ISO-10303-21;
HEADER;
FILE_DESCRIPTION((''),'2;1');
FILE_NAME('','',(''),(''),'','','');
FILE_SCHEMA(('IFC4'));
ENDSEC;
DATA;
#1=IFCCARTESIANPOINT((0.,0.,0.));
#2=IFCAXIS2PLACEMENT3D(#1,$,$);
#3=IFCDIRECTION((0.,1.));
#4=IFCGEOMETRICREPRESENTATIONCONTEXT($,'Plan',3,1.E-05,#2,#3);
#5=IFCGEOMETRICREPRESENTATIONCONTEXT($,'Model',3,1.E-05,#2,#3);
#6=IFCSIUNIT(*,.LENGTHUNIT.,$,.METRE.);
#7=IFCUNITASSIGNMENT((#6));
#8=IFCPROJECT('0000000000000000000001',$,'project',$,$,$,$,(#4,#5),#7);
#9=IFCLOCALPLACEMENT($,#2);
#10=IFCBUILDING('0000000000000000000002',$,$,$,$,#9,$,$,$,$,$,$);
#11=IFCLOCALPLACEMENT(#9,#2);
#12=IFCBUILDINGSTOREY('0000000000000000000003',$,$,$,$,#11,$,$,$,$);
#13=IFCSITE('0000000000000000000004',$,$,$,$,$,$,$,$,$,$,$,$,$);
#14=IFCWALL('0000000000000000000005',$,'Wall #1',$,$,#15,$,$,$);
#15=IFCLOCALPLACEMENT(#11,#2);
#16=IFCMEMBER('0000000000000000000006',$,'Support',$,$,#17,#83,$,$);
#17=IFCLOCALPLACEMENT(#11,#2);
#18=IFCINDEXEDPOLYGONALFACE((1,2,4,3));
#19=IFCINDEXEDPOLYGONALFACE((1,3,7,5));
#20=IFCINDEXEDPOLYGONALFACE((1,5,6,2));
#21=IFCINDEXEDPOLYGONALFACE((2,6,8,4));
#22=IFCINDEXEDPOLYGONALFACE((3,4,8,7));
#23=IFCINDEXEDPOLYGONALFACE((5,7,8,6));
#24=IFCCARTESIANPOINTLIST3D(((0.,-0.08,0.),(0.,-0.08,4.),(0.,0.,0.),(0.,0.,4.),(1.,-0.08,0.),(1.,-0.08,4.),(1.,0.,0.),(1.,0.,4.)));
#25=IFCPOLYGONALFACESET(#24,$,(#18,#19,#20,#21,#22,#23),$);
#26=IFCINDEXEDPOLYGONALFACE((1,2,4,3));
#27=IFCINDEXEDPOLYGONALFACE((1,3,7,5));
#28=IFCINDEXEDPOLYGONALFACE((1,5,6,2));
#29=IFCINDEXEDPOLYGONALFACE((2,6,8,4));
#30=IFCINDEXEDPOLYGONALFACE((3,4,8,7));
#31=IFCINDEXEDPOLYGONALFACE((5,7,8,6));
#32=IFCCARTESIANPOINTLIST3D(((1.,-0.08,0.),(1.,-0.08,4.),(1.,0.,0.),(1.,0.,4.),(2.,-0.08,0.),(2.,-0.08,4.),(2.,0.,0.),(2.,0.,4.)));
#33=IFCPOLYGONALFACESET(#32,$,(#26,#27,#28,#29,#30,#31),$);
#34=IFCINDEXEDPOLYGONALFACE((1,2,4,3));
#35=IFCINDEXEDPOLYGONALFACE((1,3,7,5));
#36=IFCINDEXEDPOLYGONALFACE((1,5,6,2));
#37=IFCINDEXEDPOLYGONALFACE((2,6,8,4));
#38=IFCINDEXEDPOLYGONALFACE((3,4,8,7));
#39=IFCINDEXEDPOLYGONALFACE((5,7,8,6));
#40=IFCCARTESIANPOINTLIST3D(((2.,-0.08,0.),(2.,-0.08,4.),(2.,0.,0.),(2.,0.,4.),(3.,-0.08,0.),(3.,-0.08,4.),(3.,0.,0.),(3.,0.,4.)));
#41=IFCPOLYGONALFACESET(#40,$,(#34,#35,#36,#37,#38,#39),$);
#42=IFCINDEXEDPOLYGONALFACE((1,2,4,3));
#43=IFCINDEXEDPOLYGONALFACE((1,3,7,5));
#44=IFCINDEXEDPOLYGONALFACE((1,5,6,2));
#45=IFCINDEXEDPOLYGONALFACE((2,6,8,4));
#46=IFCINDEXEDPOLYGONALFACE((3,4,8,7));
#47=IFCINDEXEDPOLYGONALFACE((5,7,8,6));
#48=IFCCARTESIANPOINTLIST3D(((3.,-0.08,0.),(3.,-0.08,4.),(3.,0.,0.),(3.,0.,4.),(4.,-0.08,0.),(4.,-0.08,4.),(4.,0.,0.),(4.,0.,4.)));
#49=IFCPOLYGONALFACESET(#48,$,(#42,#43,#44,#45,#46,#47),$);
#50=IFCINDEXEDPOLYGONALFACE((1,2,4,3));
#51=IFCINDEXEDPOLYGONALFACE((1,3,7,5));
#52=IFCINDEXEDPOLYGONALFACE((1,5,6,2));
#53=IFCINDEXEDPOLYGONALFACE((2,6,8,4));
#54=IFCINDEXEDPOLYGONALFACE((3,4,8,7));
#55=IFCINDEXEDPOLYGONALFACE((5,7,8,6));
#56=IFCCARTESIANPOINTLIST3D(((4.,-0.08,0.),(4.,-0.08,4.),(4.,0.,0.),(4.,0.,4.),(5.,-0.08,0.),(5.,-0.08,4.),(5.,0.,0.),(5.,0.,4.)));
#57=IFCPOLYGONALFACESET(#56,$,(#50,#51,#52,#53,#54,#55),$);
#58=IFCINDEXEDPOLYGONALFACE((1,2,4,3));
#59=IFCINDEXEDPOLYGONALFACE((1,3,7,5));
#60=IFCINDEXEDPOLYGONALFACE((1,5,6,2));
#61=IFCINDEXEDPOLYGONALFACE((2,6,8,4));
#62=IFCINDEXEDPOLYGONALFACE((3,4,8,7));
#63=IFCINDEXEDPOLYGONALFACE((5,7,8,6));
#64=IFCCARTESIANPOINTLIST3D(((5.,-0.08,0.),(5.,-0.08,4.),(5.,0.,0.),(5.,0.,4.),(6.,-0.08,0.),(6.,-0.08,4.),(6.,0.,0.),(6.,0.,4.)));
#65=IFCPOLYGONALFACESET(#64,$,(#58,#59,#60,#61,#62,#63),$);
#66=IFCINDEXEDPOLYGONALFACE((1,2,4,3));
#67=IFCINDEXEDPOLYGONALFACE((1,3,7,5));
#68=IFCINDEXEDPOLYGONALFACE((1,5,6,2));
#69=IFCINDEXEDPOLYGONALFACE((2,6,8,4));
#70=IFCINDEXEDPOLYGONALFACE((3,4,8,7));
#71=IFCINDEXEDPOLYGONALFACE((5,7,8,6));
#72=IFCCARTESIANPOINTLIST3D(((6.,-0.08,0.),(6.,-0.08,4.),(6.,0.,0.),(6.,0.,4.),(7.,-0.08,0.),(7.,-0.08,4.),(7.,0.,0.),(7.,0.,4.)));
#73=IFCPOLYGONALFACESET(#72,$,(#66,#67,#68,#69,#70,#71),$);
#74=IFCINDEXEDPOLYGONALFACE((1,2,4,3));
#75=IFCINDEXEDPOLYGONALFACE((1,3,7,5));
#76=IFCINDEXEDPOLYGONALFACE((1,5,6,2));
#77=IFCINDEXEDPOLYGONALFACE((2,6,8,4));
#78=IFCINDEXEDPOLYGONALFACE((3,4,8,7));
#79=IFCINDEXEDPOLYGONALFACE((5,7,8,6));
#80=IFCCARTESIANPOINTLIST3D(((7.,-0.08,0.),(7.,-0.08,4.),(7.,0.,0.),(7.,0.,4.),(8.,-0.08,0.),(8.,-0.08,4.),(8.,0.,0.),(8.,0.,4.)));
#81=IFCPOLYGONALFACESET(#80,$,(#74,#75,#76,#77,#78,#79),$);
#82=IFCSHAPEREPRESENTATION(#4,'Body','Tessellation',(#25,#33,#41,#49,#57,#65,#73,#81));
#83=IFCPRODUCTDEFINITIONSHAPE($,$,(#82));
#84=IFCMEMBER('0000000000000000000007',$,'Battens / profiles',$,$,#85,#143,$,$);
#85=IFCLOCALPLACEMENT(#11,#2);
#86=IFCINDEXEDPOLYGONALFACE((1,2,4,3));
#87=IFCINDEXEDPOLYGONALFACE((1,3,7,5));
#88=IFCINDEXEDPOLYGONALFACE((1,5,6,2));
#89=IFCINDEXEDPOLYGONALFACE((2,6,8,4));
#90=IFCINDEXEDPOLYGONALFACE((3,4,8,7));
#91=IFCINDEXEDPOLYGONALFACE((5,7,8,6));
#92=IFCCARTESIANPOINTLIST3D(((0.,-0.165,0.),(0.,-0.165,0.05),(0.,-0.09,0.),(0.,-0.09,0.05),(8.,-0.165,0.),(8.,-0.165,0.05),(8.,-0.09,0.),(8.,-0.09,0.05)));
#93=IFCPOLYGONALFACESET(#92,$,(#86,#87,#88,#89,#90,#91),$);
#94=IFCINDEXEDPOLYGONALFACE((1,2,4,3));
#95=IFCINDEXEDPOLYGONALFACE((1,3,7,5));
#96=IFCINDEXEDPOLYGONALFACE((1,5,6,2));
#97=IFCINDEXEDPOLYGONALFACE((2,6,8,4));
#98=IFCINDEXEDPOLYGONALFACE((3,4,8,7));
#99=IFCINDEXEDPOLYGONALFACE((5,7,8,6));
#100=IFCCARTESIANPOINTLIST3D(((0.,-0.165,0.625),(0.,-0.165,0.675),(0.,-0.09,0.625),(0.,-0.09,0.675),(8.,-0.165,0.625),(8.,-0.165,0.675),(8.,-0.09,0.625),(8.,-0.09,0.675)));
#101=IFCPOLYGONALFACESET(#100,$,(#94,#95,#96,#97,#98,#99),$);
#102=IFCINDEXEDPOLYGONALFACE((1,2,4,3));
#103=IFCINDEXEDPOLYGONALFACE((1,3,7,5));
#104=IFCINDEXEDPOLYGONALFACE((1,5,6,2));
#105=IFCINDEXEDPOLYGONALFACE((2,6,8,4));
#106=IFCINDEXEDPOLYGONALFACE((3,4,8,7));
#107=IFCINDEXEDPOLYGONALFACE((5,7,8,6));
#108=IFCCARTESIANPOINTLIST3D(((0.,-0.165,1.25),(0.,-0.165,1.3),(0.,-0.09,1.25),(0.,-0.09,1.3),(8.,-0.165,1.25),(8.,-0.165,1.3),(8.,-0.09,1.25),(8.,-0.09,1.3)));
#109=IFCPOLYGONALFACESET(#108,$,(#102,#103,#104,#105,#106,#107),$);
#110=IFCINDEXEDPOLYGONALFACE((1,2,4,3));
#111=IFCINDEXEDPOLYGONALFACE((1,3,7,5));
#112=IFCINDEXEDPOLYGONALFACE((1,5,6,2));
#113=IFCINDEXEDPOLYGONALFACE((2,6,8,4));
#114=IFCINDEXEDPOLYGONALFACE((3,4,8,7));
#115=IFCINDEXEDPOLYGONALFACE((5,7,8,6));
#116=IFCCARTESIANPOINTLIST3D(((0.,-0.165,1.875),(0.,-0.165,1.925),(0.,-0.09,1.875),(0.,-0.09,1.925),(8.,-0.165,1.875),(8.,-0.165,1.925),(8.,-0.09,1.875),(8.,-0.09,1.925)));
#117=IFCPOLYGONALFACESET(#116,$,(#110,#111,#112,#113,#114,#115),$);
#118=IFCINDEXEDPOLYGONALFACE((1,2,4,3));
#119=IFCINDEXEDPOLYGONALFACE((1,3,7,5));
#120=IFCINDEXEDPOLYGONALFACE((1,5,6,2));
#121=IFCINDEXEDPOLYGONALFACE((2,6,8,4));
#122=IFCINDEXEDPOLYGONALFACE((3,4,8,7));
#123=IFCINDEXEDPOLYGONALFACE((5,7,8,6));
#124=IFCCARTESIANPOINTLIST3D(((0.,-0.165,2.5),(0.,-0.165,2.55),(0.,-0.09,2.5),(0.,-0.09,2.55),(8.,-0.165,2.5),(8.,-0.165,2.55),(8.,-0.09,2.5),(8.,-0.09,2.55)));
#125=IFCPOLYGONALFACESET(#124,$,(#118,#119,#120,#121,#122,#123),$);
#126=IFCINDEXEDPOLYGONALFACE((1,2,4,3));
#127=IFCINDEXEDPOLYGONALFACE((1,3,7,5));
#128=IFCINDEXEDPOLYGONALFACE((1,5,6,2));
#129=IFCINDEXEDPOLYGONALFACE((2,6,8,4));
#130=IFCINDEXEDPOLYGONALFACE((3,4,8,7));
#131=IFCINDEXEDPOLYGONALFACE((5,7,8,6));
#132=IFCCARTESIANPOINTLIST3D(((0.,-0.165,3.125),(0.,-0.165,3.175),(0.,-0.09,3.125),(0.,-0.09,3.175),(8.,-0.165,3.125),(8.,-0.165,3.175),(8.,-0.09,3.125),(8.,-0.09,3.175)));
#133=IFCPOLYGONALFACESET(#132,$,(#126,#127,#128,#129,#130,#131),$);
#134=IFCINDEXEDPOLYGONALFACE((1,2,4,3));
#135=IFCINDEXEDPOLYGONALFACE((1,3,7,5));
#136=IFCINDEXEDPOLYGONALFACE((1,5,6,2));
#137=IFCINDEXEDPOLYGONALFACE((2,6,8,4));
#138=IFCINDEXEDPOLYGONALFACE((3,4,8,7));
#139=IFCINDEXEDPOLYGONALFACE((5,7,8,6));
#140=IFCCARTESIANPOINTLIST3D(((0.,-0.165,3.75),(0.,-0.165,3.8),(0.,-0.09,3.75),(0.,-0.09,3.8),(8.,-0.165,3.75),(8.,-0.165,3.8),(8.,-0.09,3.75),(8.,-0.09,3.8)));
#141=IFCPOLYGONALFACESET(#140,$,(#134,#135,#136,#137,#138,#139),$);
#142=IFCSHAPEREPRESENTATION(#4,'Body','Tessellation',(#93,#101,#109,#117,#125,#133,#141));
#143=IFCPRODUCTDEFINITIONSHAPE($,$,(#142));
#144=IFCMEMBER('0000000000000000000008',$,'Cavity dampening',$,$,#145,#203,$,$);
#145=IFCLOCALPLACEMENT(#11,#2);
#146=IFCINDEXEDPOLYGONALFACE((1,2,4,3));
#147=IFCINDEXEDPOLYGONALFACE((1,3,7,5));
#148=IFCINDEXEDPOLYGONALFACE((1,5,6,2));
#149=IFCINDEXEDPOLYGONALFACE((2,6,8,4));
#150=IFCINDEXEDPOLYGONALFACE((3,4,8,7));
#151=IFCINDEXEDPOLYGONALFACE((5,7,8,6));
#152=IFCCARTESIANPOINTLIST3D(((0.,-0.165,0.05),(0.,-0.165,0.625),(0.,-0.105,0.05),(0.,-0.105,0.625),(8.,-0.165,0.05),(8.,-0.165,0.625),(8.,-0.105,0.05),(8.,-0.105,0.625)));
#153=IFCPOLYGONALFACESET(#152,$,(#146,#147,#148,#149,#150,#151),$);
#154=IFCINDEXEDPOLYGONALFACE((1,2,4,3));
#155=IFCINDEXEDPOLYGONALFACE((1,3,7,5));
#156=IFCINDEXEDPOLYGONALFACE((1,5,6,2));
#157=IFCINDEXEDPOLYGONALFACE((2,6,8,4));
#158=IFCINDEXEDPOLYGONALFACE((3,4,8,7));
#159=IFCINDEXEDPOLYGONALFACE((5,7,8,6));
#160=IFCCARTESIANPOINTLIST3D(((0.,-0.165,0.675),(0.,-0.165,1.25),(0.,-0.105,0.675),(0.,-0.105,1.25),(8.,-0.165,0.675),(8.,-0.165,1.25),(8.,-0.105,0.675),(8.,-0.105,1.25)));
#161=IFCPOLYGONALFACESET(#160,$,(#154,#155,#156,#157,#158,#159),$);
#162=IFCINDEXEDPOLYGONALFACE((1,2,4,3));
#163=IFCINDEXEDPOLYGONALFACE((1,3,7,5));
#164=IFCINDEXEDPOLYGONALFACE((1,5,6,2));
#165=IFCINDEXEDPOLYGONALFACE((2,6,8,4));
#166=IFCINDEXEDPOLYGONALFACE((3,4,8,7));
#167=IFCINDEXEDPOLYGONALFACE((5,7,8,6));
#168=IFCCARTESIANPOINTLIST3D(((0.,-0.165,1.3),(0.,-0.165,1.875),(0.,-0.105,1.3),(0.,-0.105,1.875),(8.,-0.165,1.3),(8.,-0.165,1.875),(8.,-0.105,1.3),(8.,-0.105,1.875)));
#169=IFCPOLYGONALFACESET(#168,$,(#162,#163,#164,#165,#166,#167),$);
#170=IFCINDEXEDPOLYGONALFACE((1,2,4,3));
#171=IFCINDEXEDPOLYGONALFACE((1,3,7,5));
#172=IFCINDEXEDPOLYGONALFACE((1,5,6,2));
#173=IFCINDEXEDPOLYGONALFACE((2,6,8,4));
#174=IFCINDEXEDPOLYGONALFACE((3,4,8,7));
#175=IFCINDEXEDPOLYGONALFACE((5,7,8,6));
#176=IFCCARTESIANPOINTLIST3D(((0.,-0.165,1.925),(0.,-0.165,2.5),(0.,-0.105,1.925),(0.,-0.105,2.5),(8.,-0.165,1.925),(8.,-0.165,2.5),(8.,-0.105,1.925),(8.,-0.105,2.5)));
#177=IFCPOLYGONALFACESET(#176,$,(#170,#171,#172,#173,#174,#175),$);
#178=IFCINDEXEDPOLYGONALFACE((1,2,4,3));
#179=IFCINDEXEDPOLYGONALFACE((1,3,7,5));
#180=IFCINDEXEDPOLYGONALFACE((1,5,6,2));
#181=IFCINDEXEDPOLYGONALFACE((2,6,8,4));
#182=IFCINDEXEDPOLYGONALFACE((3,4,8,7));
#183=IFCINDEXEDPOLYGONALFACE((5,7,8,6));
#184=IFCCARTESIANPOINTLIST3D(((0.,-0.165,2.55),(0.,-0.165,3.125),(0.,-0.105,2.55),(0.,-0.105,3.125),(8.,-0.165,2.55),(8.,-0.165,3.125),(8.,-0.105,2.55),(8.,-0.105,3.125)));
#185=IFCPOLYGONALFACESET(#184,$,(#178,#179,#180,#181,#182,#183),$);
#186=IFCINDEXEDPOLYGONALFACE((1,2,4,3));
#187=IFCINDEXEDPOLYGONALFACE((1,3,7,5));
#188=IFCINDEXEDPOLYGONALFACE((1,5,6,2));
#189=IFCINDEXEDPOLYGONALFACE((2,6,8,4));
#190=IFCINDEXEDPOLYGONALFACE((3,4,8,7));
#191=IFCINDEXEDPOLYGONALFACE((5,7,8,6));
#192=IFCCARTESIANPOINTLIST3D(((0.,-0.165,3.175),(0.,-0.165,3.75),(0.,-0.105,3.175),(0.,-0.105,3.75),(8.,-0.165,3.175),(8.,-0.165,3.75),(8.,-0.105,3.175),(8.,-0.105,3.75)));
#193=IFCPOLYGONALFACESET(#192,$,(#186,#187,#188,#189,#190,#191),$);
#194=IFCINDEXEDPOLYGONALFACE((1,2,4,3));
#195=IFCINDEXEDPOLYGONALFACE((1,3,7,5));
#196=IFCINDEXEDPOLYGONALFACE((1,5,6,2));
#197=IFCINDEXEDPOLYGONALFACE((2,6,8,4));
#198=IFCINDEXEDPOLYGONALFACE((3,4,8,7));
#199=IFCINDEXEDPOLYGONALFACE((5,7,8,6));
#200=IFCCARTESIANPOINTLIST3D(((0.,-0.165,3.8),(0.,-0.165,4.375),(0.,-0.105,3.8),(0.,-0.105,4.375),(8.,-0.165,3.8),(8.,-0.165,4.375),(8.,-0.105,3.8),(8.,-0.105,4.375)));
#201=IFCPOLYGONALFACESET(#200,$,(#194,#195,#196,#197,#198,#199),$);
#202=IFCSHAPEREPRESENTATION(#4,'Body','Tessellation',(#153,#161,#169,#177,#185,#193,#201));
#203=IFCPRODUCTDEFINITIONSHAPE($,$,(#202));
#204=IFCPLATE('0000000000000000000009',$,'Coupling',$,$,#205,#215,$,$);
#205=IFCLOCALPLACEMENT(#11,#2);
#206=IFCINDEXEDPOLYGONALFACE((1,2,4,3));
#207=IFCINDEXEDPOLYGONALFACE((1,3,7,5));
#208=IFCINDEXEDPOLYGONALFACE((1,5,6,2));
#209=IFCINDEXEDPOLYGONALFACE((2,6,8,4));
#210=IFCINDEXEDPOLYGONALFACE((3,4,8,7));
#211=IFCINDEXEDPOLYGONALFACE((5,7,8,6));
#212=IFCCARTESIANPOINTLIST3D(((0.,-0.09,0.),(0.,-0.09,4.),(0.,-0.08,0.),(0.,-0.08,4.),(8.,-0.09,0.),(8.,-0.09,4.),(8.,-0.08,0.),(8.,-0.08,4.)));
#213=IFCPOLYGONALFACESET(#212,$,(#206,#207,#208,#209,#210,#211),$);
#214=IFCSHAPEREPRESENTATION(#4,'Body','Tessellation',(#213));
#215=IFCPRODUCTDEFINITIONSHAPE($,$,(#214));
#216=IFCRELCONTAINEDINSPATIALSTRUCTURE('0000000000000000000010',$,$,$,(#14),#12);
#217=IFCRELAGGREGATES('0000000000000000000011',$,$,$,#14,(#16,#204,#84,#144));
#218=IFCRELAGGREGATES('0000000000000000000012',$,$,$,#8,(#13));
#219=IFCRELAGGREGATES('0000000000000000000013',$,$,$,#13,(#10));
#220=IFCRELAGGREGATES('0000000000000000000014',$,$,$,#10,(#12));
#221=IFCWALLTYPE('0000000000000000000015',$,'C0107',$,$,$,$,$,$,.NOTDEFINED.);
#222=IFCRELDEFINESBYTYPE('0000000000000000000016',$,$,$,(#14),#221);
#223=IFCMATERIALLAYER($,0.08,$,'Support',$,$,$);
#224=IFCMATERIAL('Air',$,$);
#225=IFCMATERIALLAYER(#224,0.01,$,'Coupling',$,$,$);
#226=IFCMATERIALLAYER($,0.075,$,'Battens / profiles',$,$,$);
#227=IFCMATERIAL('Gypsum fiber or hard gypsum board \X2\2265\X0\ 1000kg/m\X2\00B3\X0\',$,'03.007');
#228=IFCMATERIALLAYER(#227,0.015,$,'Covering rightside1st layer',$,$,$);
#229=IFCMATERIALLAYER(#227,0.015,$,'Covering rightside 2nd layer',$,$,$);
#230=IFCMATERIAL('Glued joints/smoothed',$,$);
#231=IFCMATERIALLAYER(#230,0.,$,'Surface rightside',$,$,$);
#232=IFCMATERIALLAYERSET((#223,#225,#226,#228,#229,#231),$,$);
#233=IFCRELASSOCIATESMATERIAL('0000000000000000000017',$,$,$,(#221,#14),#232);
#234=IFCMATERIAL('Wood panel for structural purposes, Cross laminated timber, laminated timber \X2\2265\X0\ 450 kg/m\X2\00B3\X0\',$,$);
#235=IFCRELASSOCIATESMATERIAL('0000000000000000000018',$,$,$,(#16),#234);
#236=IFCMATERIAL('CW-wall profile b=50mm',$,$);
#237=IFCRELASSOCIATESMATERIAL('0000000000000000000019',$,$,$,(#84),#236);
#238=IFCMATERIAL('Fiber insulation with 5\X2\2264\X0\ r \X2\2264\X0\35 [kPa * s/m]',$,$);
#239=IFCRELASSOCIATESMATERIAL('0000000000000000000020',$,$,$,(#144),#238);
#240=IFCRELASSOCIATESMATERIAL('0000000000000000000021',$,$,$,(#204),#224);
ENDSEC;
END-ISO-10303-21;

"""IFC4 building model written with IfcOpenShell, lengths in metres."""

from ifc_helpers import new_model, si_unit, direction, frame, frame_2d, origin, place, context, project, spatial, rectangle, extrude, material, layer, layer_set, type_object, element, aggregate, save


model = new_model("IFC4")

# Units and contexts
plan_context = context("Plan", 3, precision=1e-05, world=origin(), true_north=direction((0.0, 1.0)))
model_context = context("Model", 3, precision=1e-05, world=origin(), true_north=direction((0.0, 1.0)))
ifc_project = project(units=[si_unit("LENGTHUNIT", "METRE")], contexts=[plan_context, model_context])

# Site, building, storey
site = spatial("IfcSite", under=ifc_project)
building_placement = place(None, origin())
building = spatial("IfcBuilding", under=site, at=building_placement)
storey_placement = place(building_placement, origin())
storey = spatial("IfcBuildingStorey", under=building, at=storey_placement)

# Wall, members, plate
ifc_layer_1 = layer(None, 0.08, Name="Support")
ifc_material_1 = material(Name="Air")
ifc_layer_2 = layer(ifc_material_1, 0.01, Name="Coupling")
ifc_layer_3 = layer(None, 0.075, Name="Battens / profiles")
ifc_material_2 = material(Name="Gypsum fiber or hard gypsum board ≥ 1000kg/m³", Category="03.007")
ifc_layer_4 = layer(ifc_material_2, 0.015, Name="Covering rightside1st layer")
ifc_layer_5 = layer(ifc_material_2, 0.015, Name="Covering rightside 2nd layer")
ifc_material_3 = material(Name="Glued joints/smoothed")
ifc_layer_6 = layer(ifc_material_3, 0.0, Name="Surface rightside")
ifc_layer_set = layer_set([ifc_layer_1, ifc_layer_2, ifc_layer_3, ifc_layer_4, ifc_layer_5, ifc_layer_6])
wall_type = type_object("IfcWallType", Name="C0107", PredefinedType="NOTDEFINED", material=ifc_layer_set)
wall_placement = place(None, frame((0.0, 0.0, 0.0), z_axis=(0.0, -1.0, 0.0), x_axis=(1.0, 0.0, 0.0)))
wall = element("IfcWall", 1, at=wall_placement, inside=storey, type_object=wall_type, material=ifc_layer_set, Name="Wall #1")
ifc_material_4 = material(Name="Wood panel for structural purposes, Cross laminated timber, laminated timber ≥ 450 kg/m³")
member_1_placement = place(wall_placement, origin())
member_1 = element("IfcMember", 2, at=member_1_placement, material=ifc_material_4, Name="Support", context=plan_context, shape_type="SweptSolid", body=[
    extrude(rectangle(XDim=1.0, YDim=0.08, at=frame_2d((0.5, 0.04), x_axis=(1.0, 0.0))), frame((0.0, 4.0, 0.0), z_axis=(0.0, -1.0, 0.0), x_axis=(1.0, 0.0, 0.0)), (0.0, 0.0, 1.0), 4.0),
    extrude(rectangle(XDim=1.0, YDim=0.08, at=frame_2d((0.5, 0.04), x_axis=(1.0, 0.0))), frame((1.0, 4.0, 0.0), z_axis=(0.0, -1.0, 0.0), x_axis=(1.0, 0.0, 0.0)), (0.0, 0.0, 1.0), 4.0),
    extrude(rectangle(XDim=1.0, YDim=0.08, at=frame_2d((0.5, 0.04), x_axis=(1.0, 0.0))), frame((2.0, 4.0, 0.0), z_axis=(0.0, -1.0, 0.0), x_axis=(1.0, 0.0, 0.0)), (0.0, 0.0, 1.0), 4.0),
    extrude(rectangle(XDim=1.0, YDim=0.08, at=frame_2d((0.5, 0.04), x_axis=(1.0, 0.0))), frame((3.0, 4.0, 0.0), z_axis=(0.0, -1.0, 0.0), x_axis=(1.0, 0.0, 0.0)), (0.0, 0.0, 1.0), 4.0),
    extrude(rectangle(XDim=1.0, YDim=0.08, at=frame_2d((0.5, 0.04), x_axis=(1.0, 0.0))), frame((4.0, 4.0, 0.0), z_axis=(0.0, -1.0, 0.0), x_axis=(1.0, 0.0, 0.0)), (0.0, 0.0, 1.0), 4.0),
    extrude(rectangle(XDim=1.0, YDim=0.08, at=frame_2d((0.5, 0.04), x_axis=(1.0, 0.0))), frame((5.0, 4.0, 0.0), z_axis=(0.0, -1.0, 0.0), x_axis=(1.0, 0.0, 0.0)), (0.0, 0.0, 1.0), 4.0),
    extrude(rectangle(XDim=1.0, YDim=0.08, at=frame_2d((0.5, 0.04), x_axis=(1.0, 0.0))), frame((6.0, 4.0, 0.0), z_axis=(0.0, -1.0, 0.0), x_axis=(1.0, 0.0, 0.0)), (0.0, 0.0, 1.0), 4.0),
    extrude(rectangle(XDim=1.0, YDim=0.08, at=frame_2d((0.5, 0.04), x_axis=(1.0, 0.0))), frame((7.0, 4.0, 0.0), z_axis=(0.0, -1.0, 0.0), x_axis=(1.0, 0.0, 0.0)), (0.0, 0.0, 1.0), 4.0),
])
ifc_material_5 = material(Name="CW-wall profile b=50mm")
member_2_placement = place(wall_placement, origin())
member_2 = element("IfcMember", 3, at=member_2_placement, material=ifc_material_5, Name="Battens / profiles", context=plan_context, shape_type="SweptSolid", body=[
    extrude(rectangle(XDim=0.05, YDim=0.075, at=frame_2d((0.025, 0.0375), x_axis=(1.0, 0.0))), frame((0.0, 0.0, 0.09), z_axis=(1.0, 0.0, 0.0), x_axis=(0.0, 1.0, 0.0)), (0.0, 0.0, 1.0), 8.0),
    extrude(rectangle(XDim=0.05, YDim=0.075, at=frame_2d((0.025, 0.0375), x_axis=(1.0, 0.0))), frame((0.0, 0.625, 0.09), z_axis=(1.0, 0.0, 0.0), x_axis=(0.0, 1.0, 0.0)), (0.0, 0.0, 1.0), 8.0),
    extrude(rectangle(XDim=0.05, YDim=0.075, at=frame_2d((0.025, 0.0375), x_axis=(1.0, 0.0))), frame((0.0, 1.25, 0.09), z_axis=(1.0, 0.0, 0.0), x_axis=(0.0, 1.0, 0.0)), (0.0, 0.0, 1.0), 8.0),
    extrude(rectangle(XDim=0.05, YDim=0.075, at=frame_2d((0.025, 0.0375), x_axis=(1.0, 0.0))), frame((0.0, 1.875, 0.09), z_axis=(1.0, 0.0, 0.0), x_axis=(0.0, 1.0, 0.0)), (0.0, 0.0, 1.0), 8.0),
    extrude(rectangle(XDim=0.05, YDim=0.075, at=frame_2d((0.025, 0.0375), x_axis=(1.0, 0.0))), frame((0.0, 2.5, 0.09), z_axis=(1.0, 0.0, 0.0), x_axis=(0.0, 1.0, 0.0)), (0.0, 0.0, 1.0), 8.0),
    extrude(rectangle(XDim=0.05, YDim=0.075, at=frame_2d((0.025, 0.0375), x_axis=(1.0, 0.0))), frame((0.0, 3.125, 0.09), z_axis=(1.0, 0.0, 0.0), x_axis=(0.0, 1.0, 0.0)), (0.0, 0.0, 1.0), 8.0),
    extrude(rectangle(XDim=0.05, YDim=0.075, at=frame_2d((0.025, 0.0375), x_axis=(1.0, 0.0))), frame((0.0, 3.75, 0.09), z_axis=(1.0, 0.0, 0.0), x_axis=(0.0, 1.0, 0.0)), (0.0, 0.0, 1.0), 8.0),
])
ifc_material_6 = material(Name="Fiber insulation with 5≤ r ≤35 [kPa * s/m]")
member_3_placement = place(wall_placement, origin())
member_3 = element("IfcMember", 4, at=member_3_placement, material=ifc_material_6, Name="Cavity dampening", context=plan_context, shape_type="SweptSolid", body=[
    extrude(rectangle(XDim=0.575, YDim=0.06, at=frame_2d((0.2875, 0.03), x_axis=(1.0, 0.0))), frame((0.0, 0.05, 0.105), z_axis=(1.0, 0.0, 0.0), x_axis=(0.0, 1.0, 0.0)), (0.0, 0.0, 1.0), 8.0),
    extrude(rectangle(XDim=0.575, YDim=0.06, at=frame_2d((0.2875, 0.03), x_axis=(1.0, 0.0))), frame((0.0, 0.675, 0.105), z_axis=(1.0, 0.0, 0.0), x_axis=(0.0, 1.0, 0.0)), (0.0, 0.0, 1.0), 8.0),
    extrude(rectangle(XDim=0.575, YDim=0.06, at=frame_2d((0.2875, 0.03), x_axis=(1.0, 0.0))), frame((0.0, 1.3, 0.105), z_axis=(1.0, 0.0, 0.0), x_axis=(0.0, 1.0, 0.0)), (0.0, 0.0, 1.0), 8.0),
    extrude(rectangle(XDim=0.575, YDim=0.06, at=frame_2d((0.2875, 0.03), x_axis=(1.0, 0.0))), frame((0.0, 1.925, 0.105), z_axis=(1.0, 0.0, 0.0), x_axis=(0.0, 1.0, 0.0)), (0.0, 0.0, 1.0), 8.0),
    extrude(rectangle(XDim=0.575, YDim=0.06, at=frame_2d((0.2875, 0.03), x_axis=(1.0, 0.0))), frame((0.0, 2.55, 0.105), z_axis=(1.0, 0.0, 0.0), x_axis=(0.0, 1.0, 0.0)), (0.0, 0.0, 1.0), 8.0),
    extrude(rectangle(XDim=0.575, YDim=0.06, at=frame_2d((0.2875, 0.03), x_axis=(1.0, 0.0))), frame((0.0, 3.175, 0.105), z_axis=(1.0, 0.0, 0.0), x_axis=(0.0, 1.0, 0.0)), (0.0, 0.0, 1.0), 8.0),
    extrude(rectangle(XDim=0.575, YDim=0.06, at=frame_2d((0.2875, 0.03), x_axis=(1.0, 0.0))), frame((0.0, 3.8, 0.105), z_axis=(1.0, 0.0, 0.0), x_axis=(0.0, 1.0, 0.0)), (0.0, 0.0, 1.0), 8.0),
])
plate_1_placement = place(wall_placement, origin())
plate_1 = element("IfcPlate", 5, at=plate_1_placement, material=ifc_material_1, Name="Coupling", context=plan_context, shape_type="SweptSolid", body=[
    extrude(rectangle(XDim=8.0, YDim=4.0, at=frame_2d((4.0, 2.0), x_axis=(1.0, 0.0))), frame((0.0, 0.0, 0.08), z_axis=(0.0, 0.0, 1.0), x_axis=(1.0, 0.0, 0.0)), (0.0, 0.0, 1.0), 0.01),
])
aggregate(wall, [member_1, plate_1, member_2, member_3])

save(model, "model.ifc")
